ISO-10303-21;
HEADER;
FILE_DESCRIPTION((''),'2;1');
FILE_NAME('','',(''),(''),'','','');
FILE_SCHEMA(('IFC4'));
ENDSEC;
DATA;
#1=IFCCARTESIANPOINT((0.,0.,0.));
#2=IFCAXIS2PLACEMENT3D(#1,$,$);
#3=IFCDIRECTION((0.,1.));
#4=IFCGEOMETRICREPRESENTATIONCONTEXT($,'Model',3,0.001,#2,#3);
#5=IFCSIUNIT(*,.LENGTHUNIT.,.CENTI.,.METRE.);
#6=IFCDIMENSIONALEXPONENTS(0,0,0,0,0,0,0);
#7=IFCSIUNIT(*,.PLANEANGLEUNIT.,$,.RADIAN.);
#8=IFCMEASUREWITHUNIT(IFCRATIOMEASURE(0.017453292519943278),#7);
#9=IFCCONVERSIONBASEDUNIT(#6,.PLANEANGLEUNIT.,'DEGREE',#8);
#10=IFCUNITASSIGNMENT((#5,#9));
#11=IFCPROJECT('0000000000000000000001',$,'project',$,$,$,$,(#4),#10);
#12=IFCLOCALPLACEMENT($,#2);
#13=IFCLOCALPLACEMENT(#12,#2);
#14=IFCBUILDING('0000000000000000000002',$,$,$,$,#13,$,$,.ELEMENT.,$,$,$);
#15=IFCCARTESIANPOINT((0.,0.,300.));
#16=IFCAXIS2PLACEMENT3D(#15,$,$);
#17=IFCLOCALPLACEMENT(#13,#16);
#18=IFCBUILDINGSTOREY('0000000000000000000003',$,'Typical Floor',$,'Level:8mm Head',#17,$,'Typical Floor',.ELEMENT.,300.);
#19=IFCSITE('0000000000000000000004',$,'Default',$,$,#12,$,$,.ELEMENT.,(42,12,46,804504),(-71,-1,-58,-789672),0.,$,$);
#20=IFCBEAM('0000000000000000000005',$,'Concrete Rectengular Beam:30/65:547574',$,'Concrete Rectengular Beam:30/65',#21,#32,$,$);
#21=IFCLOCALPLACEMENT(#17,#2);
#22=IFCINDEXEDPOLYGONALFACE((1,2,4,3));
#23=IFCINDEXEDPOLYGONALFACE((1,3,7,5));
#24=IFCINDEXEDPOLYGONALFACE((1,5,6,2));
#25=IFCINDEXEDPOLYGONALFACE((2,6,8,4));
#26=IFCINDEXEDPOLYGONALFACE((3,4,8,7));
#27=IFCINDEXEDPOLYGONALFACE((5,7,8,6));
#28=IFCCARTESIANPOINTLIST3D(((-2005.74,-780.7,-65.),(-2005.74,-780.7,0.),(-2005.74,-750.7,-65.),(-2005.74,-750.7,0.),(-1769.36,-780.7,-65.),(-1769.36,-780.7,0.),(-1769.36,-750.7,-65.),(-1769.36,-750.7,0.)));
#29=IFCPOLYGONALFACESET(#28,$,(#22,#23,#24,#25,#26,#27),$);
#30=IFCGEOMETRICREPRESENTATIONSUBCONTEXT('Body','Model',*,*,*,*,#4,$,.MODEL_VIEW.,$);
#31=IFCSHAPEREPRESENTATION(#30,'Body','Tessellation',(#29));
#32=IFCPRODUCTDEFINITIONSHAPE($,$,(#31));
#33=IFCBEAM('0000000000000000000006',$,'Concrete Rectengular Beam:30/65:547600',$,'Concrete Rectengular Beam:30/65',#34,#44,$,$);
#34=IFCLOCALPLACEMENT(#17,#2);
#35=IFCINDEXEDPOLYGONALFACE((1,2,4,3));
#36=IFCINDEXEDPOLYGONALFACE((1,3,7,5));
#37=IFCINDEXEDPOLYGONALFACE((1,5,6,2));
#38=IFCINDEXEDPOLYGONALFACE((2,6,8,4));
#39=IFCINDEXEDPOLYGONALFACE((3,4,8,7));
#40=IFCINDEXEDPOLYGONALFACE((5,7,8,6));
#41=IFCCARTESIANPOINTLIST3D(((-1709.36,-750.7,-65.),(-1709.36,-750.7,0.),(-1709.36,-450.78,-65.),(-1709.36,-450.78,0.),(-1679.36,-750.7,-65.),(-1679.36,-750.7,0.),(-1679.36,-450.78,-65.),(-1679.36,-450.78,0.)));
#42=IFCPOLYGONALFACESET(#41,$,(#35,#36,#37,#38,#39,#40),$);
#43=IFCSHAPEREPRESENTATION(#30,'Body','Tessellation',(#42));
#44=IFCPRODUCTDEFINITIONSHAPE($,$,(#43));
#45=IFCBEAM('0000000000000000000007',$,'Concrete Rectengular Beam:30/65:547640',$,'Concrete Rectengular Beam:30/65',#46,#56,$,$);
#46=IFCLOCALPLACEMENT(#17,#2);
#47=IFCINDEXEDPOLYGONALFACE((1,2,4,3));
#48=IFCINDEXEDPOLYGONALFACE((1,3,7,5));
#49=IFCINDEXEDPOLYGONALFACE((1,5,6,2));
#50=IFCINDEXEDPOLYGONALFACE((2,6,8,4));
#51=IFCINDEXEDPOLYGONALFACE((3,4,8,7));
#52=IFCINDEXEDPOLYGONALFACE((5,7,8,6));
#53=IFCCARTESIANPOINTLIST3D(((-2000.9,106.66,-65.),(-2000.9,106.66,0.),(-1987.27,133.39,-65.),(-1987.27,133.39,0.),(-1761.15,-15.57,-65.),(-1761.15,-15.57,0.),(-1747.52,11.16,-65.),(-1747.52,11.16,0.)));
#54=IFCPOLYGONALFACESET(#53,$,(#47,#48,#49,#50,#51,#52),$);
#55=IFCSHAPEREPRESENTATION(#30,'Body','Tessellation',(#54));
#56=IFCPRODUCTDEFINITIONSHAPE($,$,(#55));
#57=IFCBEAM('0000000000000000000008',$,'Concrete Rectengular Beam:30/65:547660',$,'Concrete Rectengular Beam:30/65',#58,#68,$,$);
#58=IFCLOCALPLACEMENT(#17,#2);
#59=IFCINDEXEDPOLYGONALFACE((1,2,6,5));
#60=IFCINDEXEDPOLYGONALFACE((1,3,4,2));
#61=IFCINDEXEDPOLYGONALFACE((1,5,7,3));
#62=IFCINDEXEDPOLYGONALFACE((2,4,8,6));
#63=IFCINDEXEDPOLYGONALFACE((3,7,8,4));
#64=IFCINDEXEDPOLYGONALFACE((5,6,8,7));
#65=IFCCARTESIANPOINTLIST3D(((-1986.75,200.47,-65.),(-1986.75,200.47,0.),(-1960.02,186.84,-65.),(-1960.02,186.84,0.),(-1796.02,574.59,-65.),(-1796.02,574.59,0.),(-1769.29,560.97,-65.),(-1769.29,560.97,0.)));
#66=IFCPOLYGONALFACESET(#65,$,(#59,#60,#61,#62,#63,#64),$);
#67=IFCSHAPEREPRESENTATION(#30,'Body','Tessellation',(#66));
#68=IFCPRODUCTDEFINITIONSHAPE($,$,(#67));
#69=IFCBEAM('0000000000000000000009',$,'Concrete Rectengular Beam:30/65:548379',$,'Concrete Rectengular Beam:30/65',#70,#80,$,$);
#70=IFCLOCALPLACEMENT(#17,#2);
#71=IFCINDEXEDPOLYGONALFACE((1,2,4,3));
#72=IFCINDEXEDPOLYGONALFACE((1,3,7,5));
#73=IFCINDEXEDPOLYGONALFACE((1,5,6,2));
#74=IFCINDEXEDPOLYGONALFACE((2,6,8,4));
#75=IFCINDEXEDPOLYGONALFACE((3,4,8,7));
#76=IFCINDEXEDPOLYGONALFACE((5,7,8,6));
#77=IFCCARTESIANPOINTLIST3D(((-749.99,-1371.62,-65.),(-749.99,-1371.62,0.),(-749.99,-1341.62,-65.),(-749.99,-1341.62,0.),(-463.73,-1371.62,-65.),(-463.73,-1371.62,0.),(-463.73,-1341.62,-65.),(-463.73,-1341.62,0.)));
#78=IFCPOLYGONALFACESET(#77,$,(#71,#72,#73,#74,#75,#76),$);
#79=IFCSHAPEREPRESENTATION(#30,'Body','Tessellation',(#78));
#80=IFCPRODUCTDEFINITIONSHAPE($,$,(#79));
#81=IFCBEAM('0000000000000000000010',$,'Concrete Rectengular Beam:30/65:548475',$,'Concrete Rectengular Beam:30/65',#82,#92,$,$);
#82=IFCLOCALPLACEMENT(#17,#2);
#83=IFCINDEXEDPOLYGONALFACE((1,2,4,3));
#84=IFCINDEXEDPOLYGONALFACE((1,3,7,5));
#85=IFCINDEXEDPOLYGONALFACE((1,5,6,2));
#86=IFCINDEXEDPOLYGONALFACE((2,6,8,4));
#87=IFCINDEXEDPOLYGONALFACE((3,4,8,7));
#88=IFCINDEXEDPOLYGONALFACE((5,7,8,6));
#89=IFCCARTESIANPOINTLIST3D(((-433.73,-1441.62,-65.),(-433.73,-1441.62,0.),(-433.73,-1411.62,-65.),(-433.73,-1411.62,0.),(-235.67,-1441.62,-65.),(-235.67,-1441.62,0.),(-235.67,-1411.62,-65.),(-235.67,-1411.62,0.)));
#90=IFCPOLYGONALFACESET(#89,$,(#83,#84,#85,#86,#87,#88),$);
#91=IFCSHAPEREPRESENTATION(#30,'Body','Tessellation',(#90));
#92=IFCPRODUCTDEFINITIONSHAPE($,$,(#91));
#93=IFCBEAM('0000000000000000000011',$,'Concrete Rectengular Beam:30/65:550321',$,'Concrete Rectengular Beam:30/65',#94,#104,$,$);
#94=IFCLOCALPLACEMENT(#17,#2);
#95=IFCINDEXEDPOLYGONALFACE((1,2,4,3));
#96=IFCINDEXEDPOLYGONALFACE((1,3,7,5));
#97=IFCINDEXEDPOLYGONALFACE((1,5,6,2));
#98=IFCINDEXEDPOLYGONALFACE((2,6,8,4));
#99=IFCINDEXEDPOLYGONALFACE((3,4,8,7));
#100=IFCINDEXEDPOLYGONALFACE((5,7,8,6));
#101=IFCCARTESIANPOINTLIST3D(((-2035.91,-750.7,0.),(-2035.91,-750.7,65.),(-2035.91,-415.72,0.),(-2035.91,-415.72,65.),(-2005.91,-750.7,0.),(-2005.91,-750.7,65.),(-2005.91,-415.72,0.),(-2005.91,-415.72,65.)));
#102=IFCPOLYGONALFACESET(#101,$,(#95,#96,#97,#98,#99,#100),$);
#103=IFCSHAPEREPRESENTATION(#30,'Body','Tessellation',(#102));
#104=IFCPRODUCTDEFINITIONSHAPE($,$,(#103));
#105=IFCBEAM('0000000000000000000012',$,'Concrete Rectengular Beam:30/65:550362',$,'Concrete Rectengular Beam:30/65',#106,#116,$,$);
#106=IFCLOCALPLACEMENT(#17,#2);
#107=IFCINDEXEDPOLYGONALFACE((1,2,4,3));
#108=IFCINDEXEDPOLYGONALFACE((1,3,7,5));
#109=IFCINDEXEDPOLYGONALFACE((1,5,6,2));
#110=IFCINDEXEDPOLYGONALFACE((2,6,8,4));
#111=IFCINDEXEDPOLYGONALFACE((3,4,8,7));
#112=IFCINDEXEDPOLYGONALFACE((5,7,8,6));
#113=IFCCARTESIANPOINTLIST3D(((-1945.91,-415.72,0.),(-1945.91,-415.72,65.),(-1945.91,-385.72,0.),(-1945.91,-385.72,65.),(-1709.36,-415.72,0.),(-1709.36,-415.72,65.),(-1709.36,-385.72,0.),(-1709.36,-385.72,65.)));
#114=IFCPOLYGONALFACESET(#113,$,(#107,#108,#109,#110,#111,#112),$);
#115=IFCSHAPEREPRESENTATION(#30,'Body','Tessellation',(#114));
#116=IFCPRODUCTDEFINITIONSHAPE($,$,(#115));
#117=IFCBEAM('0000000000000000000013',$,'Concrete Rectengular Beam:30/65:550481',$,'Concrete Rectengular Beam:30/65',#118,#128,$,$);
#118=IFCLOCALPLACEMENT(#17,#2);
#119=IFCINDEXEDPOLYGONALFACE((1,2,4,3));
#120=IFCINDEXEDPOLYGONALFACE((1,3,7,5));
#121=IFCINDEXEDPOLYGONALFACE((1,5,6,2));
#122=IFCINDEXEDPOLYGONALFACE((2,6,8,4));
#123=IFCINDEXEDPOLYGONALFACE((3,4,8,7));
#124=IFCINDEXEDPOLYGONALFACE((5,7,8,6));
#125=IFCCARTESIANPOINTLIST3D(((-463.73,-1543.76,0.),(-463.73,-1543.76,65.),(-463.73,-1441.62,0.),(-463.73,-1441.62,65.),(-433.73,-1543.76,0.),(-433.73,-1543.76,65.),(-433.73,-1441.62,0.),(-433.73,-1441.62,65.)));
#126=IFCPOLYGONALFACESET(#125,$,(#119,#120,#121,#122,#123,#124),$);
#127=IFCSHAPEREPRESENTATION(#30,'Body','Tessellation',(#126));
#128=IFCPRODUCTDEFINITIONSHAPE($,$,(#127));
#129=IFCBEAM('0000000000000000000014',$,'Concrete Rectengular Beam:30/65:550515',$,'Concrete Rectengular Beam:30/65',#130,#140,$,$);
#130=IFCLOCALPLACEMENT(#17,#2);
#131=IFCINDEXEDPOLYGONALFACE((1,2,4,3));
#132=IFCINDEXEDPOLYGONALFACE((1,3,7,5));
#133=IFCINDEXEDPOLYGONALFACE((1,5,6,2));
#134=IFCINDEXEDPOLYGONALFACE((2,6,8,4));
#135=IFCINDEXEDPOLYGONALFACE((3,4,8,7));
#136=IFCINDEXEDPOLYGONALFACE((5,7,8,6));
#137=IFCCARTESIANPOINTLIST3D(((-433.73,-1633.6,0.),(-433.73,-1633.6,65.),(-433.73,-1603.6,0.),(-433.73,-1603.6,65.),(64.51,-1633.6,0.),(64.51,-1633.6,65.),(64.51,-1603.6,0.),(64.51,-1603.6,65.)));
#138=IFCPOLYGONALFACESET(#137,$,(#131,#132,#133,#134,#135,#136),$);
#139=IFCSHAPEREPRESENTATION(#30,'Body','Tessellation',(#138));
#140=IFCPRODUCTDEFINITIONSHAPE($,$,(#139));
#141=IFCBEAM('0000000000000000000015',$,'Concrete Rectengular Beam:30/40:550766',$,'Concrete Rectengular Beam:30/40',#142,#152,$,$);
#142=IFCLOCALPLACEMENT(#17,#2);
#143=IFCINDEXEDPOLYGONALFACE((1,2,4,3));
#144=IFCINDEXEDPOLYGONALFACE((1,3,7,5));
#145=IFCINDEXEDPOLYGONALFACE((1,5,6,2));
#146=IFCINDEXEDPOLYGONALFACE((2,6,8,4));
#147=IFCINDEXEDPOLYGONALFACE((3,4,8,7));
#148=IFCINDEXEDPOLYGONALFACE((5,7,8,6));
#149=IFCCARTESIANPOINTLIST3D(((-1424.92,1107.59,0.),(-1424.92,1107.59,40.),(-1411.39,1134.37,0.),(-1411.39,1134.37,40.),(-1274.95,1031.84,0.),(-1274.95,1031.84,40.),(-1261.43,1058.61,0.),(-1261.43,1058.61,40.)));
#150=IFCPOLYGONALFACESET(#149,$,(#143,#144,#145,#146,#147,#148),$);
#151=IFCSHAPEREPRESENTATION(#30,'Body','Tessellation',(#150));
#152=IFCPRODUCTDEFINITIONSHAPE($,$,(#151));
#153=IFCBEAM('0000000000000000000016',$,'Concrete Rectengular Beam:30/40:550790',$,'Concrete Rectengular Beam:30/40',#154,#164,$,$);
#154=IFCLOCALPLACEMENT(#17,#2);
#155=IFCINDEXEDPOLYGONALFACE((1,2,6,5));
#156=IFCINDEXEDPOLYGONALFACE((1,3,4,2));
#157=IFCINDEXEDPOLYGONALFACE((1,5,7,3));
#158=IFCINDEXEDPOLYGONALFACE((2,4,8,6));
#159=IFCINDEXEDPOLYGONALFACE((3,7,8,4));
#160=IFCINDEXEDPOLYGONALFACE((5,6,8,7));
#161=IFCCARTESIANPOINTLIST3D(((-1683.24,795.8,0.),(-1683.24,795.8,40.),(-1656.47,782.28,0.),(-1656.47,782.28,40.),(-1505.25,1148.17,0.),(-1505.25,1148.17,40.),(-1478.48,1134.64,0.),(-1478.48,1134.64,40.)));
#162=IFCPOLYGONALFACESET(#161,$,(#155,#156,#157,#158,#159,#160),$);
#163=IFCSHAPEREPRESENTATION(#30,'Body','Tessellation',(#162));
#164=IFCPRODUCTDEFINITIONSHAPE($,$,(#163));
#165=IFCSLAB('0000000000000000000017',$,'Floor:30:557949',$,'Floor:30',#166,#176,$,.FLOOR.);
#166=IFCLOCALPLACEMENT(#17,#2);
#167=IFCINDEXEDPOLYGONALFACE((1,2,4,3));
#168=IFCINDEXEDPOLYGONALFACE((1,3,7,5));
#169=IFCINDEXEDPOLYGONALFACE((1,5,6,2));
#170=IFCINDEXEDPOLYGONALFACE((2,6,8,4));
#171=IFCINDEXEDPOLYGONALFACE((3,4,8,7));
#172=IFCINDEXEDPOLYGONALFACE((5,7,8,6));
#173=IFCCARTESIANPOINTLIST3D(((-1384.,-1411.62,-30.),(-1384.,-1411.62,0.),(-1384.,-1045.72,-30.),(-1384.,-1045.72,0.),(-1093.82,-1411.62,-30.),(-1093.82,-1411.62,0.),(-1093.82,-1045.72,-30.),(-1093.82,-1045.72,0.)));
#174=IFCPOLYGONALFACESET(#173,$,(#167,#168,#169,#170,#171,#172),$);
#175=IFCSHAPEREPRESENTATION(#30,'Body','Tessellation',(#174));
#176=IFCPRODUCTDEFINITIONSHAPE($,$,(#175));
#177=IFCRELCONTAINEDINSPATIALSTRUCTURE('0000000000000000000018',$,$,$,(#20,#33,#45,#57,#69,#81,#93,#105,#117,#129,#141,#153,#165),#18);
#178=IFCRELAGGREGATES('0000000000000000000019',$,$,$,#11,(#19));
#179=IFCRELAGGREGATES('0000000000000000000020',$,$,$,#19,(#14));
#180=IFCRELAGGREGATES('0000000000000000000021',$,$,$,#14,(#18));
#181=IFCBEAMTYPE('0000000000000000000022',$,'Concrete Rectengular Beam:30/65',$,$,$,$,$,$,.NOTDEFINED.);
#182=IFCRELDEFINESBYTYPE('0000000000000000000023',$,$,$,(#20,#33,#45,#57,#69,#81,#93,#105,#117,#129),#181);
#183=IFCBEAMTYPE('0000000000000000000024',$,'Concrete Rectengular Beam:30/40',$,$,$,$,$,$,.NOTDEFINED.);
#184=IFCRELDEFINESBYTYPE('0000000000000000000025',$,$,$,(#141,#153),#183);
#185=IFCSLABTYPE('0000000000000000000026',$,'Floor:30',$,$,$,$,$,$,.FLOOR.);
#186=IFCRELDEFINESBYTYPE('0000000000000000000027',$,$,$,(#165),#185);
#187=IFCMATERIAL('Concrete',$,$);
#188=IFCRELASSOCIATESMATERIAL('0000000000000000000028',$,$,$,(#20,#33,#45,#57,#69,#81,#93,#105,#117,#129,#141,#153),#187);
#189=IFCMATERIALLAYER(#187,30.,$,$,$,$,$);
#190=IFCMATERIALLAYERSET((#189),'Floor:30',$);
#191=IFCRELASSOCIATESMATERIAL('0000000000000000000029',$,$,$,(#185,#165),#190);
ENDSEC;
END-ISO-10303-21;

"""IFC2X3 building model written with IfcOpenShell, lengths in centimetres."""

from ifc_helpers import new_model, entity, si_unit, converted_unit, direction, frame, frame_2d, origin, origin_2d_with_axis, place, context, subcontext, project, spatial, rectangle, extrude, material, layer, layer_set, layer_usage, type_object, element, save


model = new_model("IFC2X3")

# Units and contexts
model_context = context("Model", 3, precision=0.001, world=origin(), true_north=direction((0.0, 1.0)))
body_context = subcontext(model_context, "Body", "Model", "MODEL_VIEW")
ifc_project = project(units=[si_unit("LENGTHUNIT", "METRE", prefix="CENTI"), converted_unit("PLANEANGLEUNIT", "DEGREE", entity("IfcRatioMeasure", 0.017453292519943278), si_unit("PLANEANGLEUNIT", "RADIAN"), dimensions=[0, 0, 0, 0, 0, 0, 0])], contexts=[model_context])

# Site, building, storey
site_placement = place(None, origin())
site = spatial("IfcSite", under=ifc_project, at=site_placement, Name="Default", CompositionType="ELEMENT", RefLatitude=(42, 12, 46, 804504), RefLongitude=(-71, -1, -58, -789672), RefElevation=0.0)
building_placement = place(site_placement, origin())
building = spatial("IfcBuilding", under=site, at=building_placement, CompositionType="ELEMENT")
storey_placement = place(building_placement, frame((0.0, 0.0, 300.0)))
storey = spatial("IfcBuildingStorey", under=building, at=storey_placement, Name="Typical Floor", ObjectType="Level:8mm Head", LongName="Typical Floor", CompositionType="ELEMENT", Elevation=300.0)

# Beams
ifc_material = material(Name="Concrete")
beam_type_1 = type_object("IfcBeamType", Name="Concrete Rectengular Beam:30/65", PredefinedType="NOTDEFINED")
beam_1_placement = place(storey_placement, frame((-2020.74, -765.7, 0.0)))
element("IfcBeam", 1, at=beam_1_placement, inside=storey, type_object=beam_type_1, material=ifc_material, Name="Concrete Rectengular Beam:30/65:547574", ObjectType="Concrete Rectengular Beam:30/65", context=body_context, shape_type="SweptSolid", body=[
    extrude(rectangle(XDim=65.0, YDim=30.0, at=frame_2d((0.0, 0.0), x_axis=(1.0, 0.0))), frame((15.0, 0.0, -32.5), z_axis=(1.0, 0.0, 0.0), x_axis=(0.0, 0.0, -1.0)), (0.0, 0.0, 1.0), 236.38),
])
beam_2_placement = place(storey_placement, frame((-1694.36, -765.7, 0.0), z_axis=(0.0, 0.0, 1.0), x_axis=(0.0, 1.0, 0.0)))
element("IfcBeam", 2, at=beam_2_placement, inside=storey, type_object=beam_type_1, material=ifc_material, Name="Concrete Rectengular Beam:30/65:547600", ObjectType="Concrete Rectengular Beam:30/65", context=body_context, shape_type="SweptSolid", body=[
    extrude(rectangle(XDim=65.0, YDim=30.0, at=frame_2d((0.0, 0.0), x_axis=(1.0, 0.0))), frame((15.0, 0.0, -32.5), z_axis=(1.0, 0.0, 0.0), x_axis=(0.0, 0.0, -1.0)), (0.0, 0.0, 1.0), 299.92),
])
beam_3_placement = place(storey_placement, frame((-1754.34, -2.2, 0.0), z_axis=(0.0, 0.0, 1.0), x_axis=(-0.890906, 0.454187, 0.0)))
element("IfcBeam", 3, at=beam_3_placement, inside=storey, type_object=beam_type_1, material=ifc_material, Name="Concrete Rectengular Beam:30/65:547640", ObjectType="Concrete Rectengular Beam:30/65", context=body_context, shape_type="SweptSolid", body=[
    extrude(rectangle(XDim=65.0, YDim=30.0, at=frame_2d((0.0, 0.0), x_axis=(1.0, 0.0))), frame((0.0, 0.0, -32.5), z_axis=(1.0, 0.0, 0.0), x_axis=(0.0, 0.0, -1.0)), (0.0, 0.0, 1.0), 269.11),
])
beam_4_placement = place(storey_placement, frame((-1973.39, 193.65, 0.0), z_axis=(0.0, 0.0, 1.0), x_axis=(0.454187, 0.890906, 0.0)))
element("IfcBeam", 4, at=beam_4_placement, inside=storey, type_object=beam_type_1, material=ifc_material, Name="Concrete Rectengular Beam:30/65:547660", ObjectType="Concrete Rectengular Beam:30/65", context=body_context, shape_type="SweptSolid", body=[
    extrude(rectangle(XDim=65.0, YDim=30.0, at=frame_2d((0.0, 0.0), x_axis=(1.0, 0.0))), frame((0.0, 0.0, -32.5), z_axis=(1.0, 0.0, 0.0), x_axis=(0.0, 0.0, -1.0)), (0.0, 0.0, 1.0), 419.94),
])
beam_5_placement = place(storey_placement, frame((-764.99, -1356.62, 0.0)))
element("IfcBeam", 5, at=beam_5_placement, inside=storey, type_object=beam_type_1, material=ifc_material, Name="Concrete Rectengular Beam:30/65:548379", ObjectType="Concrete Rectengular Beam:30/65", context=body_context, shape_type="SweptSolid", body=[
    extrude(rectangle(XDim=65.0, YDim=30.0, at=frame_2d((0.0, 0.0), x_axis=(1.0, 0.0))), frame((15.0, 0.0, -32.5), z_axis=(1.0, 0.0, 0.0), x_axis=(0.0, 0.0, -1.0)), (0.0, 0.0, 1.0), 286.26),
])
beam_6_placement = place(storey_placement, frame((-448.73, -1426.62, 0.0)))
element("IfcBeam", 6, at=beam_6_placement, inside=storey, type_object=beam_type_1, material=ifc_material, Name="Concrete Rectengular Beam:30/65:548475", ObjectType="Concrete Rectengular Beam:30/65", context=body_context, shape_type="SweptSolid", body=[
    extrude(rectangle(XDim=65.0, YDim=30.0, at=frame_2d((0.0, 0.0), x_axis=(1.0, 0.0))), frame((15.0, 0.0, -32.5), z_axis=(1.0, 0.0, 0.0), x_axis=(0.0, 0.0, -1.0)), (0.0, 0.0, 1.0), 198.06),
])
beam_7_placement = place(storey_placement, frame((-2020.91, -415.72, 0.0), z_axis=(0.0, 0.0, 1.0), x_axis=(0.0, -1.0, 0.0)))
element("IfcBeam", 7, at=beam_7_placement, inside=storey, type_object=beam_type_1, material=ifc_material, Name="Concrete Rectengular Beam:30/65:550321", ObjectType="Concrete Rectengular Beam:30/65", context=body_context, shape_type="SweptSolid", body=[
    extrude(rectangle(XDim=65.0, YDim=30.0, at=frame_2d((0.0, 0.0), x_axis=(1.0, 0.0))), frame((0.0, 0.0, 32.5), z_axis=(1.0, 0.0, 0.0), x_axis=(0.0, 0.0, -1.0)), (0.0, 0.0, 1.0), 334.98),
])
beam_8_placement = place(storey_placement, frame((-1945.91, -400.72, 0.0)))
element("IfcBeam", 8, at=beam_8_placement, inside=storey, type_object=beam_type_1, material=ifc_material, Name="Concrete Rectengular Beam:30/65:550362", ObjectType="Concrete Rectengular Beam:30/65", context=body_context, shape_type="SweptSolid", body=[
    extrude(rectangle(XDim=65.0, YDim=30.0, at=frame_2d((0.0, 0.0), x_axis=(1.0, 0.0))), frame((0.0, 0.0, 32.5), z_axis=(1.0, 0.0, 0.0), x_axis=(0.0, 0.0, -1.0)), (0.0, 0.0, 1.0), 236.55),
])
beam_9_placement = place(storey_placement, frame((-448.73, -1441.62, 0.0), z_axis=(0.0, 0.0, 1.0), x_axis=(0.0, -1.0, 0.0)))
element("IfcBeam", 9, at=beam_9_placement, inside=storey, type_object=beam_type_1, material=ifc_material, Name="Concrete Rectengular Beam:30/65:550481", ObjectType="Concrete Rectengular Beam:30/65", context=body_context, shape_type="SweptSolid", body=[
    extrude(rectangle(XDim=65.0, YDim=30.0, at=origin_2d_with_axis()), frame((0.0, 0.0, 32.5), z_axis=(1.0, 0.0, 0.0), x_axis=(0.0, 0.0, -1.0)), (0.0, 0.0, 1.0), 102.13),
])
beam_10_placement = place(storey_placement, frame((-433.73, -1618.6, 0.0)))
element("IfcBeam", 10, at=beam_10_placement, inside=storey, type_object=beam_type_1, material=ifc_material, Name="Concrete Rectengular Beam:30/65:550515", ObjectType="Concrete Rectengular Beam:30/65", context=body_context, shape_type="SweptSolid", body=[
    extrude(rectangle(XDim=65.0, YDim=30.0, at=frame_2d((0.0, 0.0), x_axis=(1.0, 0.0))), frame((0.0, 0.0, 32.5), z_axis=(1.0, 0.0, 0.0), x_axis=(0.0, 0.0, -1.0)), (0.0, 0.0, 1.0), 498.24),
])
beam_type_2 = type_object("IfcBeamType", Name="Concrete Rectengular Beam:30/40", PredefinedType="NOTDEFINED")
beam_11_placement = place(storey_placement, frame((-1268.19, 1045.23, 0.0), z_axis=(0.0, 0.0, 1.0), x_axis=(-0.892587, 0.450875, 0.0)))
element("IfcBeam", 11, at=beam_11_placement, inside=storey, type_object=beam_type_2, material=ifc_material, Name="Concrete Rectengular Beam:30/40:550766", ObjectType="Concrete Rectengular Beam:30/40", context=body_context, shape_type="SweptSolid", body=[
    extrude(rectangle(XDim=40.0, YDim=30.0, at=frame_2d((0.0, 0.0), x_axis=(1.0, 0.0))), frame((0.0, 0.0, 20.0), z_axis=(1.0, 0.0, 0.0), x_axis=(0.0, 0.0, -1.0)), (0.0, 0.0, 1.0), 168.01),
])
beam_12_placement = place(storey_placement, frame((-1491.86, 1141.41, 0.0), z_axis=(0.0, 0.0, 1.0), x_axis=(-0.450875, -0.892587, 0.0)))
element("IfcBeam", 12, at=beam_12_placement, inside=storey, type_object=beam_type_2, material=ifc_material, Name="Concrete Rectengular Beam:30/40:550790", ObjectType="Concrete Rectengular Beam:30/40", context=body_context, shape_type="SweptSolid", body=[
    extrude(rectangle(XDim=40.0, YDim=30.0, at=origin_2d_with_axis()), frame((0.0, 0.0, 20.0), z_axis=(1.0, 0.0, 0.0), x_axis=(0.0, 0.0, -1.0)), (0.0, 0.0, 1.0), 394.77),
])

# Slab
ifc_layer = layer(ifc_material, 30.0)
ifc_layer_set = layer_set([ifc_layer], Name="Floor:30")
ifc_layer_usage_1 = layer_usage(ifc_layer_set, "AXIS3", "POSITIVE", 0.0)
slab_type_1 = type_object("IfcSlabType", Name="Floor:30", PredefinedType="FLOOR", material=ifc_layer_set)
slab_1_placement = place(storey_placement, origin())
element("IfcSlab", 13, at=slab_1_placement, inside=storey, type_object=slab_type_1, material=ifc_layer_usage_1, Name="Floor:30:557949", ObjectType="Floor:30", PredefinedType="FLOOR", context=body_context, shape_type="SweptSolid", body=[
    extrude(rectangle(XDim=365.9, YDim=290.18, at=frame_2d((0.0, 0.0), x_axis=(1.0, 0.0))), frame((-1238.91, -1228.67, 0.0), z_axis=(0.0, 0.0, -1.0), x_axis=(0.0, 1.0, 0.0)), (0.0, 0.0, 1.0), 30.0),
])

save(model, "model.ifc")
